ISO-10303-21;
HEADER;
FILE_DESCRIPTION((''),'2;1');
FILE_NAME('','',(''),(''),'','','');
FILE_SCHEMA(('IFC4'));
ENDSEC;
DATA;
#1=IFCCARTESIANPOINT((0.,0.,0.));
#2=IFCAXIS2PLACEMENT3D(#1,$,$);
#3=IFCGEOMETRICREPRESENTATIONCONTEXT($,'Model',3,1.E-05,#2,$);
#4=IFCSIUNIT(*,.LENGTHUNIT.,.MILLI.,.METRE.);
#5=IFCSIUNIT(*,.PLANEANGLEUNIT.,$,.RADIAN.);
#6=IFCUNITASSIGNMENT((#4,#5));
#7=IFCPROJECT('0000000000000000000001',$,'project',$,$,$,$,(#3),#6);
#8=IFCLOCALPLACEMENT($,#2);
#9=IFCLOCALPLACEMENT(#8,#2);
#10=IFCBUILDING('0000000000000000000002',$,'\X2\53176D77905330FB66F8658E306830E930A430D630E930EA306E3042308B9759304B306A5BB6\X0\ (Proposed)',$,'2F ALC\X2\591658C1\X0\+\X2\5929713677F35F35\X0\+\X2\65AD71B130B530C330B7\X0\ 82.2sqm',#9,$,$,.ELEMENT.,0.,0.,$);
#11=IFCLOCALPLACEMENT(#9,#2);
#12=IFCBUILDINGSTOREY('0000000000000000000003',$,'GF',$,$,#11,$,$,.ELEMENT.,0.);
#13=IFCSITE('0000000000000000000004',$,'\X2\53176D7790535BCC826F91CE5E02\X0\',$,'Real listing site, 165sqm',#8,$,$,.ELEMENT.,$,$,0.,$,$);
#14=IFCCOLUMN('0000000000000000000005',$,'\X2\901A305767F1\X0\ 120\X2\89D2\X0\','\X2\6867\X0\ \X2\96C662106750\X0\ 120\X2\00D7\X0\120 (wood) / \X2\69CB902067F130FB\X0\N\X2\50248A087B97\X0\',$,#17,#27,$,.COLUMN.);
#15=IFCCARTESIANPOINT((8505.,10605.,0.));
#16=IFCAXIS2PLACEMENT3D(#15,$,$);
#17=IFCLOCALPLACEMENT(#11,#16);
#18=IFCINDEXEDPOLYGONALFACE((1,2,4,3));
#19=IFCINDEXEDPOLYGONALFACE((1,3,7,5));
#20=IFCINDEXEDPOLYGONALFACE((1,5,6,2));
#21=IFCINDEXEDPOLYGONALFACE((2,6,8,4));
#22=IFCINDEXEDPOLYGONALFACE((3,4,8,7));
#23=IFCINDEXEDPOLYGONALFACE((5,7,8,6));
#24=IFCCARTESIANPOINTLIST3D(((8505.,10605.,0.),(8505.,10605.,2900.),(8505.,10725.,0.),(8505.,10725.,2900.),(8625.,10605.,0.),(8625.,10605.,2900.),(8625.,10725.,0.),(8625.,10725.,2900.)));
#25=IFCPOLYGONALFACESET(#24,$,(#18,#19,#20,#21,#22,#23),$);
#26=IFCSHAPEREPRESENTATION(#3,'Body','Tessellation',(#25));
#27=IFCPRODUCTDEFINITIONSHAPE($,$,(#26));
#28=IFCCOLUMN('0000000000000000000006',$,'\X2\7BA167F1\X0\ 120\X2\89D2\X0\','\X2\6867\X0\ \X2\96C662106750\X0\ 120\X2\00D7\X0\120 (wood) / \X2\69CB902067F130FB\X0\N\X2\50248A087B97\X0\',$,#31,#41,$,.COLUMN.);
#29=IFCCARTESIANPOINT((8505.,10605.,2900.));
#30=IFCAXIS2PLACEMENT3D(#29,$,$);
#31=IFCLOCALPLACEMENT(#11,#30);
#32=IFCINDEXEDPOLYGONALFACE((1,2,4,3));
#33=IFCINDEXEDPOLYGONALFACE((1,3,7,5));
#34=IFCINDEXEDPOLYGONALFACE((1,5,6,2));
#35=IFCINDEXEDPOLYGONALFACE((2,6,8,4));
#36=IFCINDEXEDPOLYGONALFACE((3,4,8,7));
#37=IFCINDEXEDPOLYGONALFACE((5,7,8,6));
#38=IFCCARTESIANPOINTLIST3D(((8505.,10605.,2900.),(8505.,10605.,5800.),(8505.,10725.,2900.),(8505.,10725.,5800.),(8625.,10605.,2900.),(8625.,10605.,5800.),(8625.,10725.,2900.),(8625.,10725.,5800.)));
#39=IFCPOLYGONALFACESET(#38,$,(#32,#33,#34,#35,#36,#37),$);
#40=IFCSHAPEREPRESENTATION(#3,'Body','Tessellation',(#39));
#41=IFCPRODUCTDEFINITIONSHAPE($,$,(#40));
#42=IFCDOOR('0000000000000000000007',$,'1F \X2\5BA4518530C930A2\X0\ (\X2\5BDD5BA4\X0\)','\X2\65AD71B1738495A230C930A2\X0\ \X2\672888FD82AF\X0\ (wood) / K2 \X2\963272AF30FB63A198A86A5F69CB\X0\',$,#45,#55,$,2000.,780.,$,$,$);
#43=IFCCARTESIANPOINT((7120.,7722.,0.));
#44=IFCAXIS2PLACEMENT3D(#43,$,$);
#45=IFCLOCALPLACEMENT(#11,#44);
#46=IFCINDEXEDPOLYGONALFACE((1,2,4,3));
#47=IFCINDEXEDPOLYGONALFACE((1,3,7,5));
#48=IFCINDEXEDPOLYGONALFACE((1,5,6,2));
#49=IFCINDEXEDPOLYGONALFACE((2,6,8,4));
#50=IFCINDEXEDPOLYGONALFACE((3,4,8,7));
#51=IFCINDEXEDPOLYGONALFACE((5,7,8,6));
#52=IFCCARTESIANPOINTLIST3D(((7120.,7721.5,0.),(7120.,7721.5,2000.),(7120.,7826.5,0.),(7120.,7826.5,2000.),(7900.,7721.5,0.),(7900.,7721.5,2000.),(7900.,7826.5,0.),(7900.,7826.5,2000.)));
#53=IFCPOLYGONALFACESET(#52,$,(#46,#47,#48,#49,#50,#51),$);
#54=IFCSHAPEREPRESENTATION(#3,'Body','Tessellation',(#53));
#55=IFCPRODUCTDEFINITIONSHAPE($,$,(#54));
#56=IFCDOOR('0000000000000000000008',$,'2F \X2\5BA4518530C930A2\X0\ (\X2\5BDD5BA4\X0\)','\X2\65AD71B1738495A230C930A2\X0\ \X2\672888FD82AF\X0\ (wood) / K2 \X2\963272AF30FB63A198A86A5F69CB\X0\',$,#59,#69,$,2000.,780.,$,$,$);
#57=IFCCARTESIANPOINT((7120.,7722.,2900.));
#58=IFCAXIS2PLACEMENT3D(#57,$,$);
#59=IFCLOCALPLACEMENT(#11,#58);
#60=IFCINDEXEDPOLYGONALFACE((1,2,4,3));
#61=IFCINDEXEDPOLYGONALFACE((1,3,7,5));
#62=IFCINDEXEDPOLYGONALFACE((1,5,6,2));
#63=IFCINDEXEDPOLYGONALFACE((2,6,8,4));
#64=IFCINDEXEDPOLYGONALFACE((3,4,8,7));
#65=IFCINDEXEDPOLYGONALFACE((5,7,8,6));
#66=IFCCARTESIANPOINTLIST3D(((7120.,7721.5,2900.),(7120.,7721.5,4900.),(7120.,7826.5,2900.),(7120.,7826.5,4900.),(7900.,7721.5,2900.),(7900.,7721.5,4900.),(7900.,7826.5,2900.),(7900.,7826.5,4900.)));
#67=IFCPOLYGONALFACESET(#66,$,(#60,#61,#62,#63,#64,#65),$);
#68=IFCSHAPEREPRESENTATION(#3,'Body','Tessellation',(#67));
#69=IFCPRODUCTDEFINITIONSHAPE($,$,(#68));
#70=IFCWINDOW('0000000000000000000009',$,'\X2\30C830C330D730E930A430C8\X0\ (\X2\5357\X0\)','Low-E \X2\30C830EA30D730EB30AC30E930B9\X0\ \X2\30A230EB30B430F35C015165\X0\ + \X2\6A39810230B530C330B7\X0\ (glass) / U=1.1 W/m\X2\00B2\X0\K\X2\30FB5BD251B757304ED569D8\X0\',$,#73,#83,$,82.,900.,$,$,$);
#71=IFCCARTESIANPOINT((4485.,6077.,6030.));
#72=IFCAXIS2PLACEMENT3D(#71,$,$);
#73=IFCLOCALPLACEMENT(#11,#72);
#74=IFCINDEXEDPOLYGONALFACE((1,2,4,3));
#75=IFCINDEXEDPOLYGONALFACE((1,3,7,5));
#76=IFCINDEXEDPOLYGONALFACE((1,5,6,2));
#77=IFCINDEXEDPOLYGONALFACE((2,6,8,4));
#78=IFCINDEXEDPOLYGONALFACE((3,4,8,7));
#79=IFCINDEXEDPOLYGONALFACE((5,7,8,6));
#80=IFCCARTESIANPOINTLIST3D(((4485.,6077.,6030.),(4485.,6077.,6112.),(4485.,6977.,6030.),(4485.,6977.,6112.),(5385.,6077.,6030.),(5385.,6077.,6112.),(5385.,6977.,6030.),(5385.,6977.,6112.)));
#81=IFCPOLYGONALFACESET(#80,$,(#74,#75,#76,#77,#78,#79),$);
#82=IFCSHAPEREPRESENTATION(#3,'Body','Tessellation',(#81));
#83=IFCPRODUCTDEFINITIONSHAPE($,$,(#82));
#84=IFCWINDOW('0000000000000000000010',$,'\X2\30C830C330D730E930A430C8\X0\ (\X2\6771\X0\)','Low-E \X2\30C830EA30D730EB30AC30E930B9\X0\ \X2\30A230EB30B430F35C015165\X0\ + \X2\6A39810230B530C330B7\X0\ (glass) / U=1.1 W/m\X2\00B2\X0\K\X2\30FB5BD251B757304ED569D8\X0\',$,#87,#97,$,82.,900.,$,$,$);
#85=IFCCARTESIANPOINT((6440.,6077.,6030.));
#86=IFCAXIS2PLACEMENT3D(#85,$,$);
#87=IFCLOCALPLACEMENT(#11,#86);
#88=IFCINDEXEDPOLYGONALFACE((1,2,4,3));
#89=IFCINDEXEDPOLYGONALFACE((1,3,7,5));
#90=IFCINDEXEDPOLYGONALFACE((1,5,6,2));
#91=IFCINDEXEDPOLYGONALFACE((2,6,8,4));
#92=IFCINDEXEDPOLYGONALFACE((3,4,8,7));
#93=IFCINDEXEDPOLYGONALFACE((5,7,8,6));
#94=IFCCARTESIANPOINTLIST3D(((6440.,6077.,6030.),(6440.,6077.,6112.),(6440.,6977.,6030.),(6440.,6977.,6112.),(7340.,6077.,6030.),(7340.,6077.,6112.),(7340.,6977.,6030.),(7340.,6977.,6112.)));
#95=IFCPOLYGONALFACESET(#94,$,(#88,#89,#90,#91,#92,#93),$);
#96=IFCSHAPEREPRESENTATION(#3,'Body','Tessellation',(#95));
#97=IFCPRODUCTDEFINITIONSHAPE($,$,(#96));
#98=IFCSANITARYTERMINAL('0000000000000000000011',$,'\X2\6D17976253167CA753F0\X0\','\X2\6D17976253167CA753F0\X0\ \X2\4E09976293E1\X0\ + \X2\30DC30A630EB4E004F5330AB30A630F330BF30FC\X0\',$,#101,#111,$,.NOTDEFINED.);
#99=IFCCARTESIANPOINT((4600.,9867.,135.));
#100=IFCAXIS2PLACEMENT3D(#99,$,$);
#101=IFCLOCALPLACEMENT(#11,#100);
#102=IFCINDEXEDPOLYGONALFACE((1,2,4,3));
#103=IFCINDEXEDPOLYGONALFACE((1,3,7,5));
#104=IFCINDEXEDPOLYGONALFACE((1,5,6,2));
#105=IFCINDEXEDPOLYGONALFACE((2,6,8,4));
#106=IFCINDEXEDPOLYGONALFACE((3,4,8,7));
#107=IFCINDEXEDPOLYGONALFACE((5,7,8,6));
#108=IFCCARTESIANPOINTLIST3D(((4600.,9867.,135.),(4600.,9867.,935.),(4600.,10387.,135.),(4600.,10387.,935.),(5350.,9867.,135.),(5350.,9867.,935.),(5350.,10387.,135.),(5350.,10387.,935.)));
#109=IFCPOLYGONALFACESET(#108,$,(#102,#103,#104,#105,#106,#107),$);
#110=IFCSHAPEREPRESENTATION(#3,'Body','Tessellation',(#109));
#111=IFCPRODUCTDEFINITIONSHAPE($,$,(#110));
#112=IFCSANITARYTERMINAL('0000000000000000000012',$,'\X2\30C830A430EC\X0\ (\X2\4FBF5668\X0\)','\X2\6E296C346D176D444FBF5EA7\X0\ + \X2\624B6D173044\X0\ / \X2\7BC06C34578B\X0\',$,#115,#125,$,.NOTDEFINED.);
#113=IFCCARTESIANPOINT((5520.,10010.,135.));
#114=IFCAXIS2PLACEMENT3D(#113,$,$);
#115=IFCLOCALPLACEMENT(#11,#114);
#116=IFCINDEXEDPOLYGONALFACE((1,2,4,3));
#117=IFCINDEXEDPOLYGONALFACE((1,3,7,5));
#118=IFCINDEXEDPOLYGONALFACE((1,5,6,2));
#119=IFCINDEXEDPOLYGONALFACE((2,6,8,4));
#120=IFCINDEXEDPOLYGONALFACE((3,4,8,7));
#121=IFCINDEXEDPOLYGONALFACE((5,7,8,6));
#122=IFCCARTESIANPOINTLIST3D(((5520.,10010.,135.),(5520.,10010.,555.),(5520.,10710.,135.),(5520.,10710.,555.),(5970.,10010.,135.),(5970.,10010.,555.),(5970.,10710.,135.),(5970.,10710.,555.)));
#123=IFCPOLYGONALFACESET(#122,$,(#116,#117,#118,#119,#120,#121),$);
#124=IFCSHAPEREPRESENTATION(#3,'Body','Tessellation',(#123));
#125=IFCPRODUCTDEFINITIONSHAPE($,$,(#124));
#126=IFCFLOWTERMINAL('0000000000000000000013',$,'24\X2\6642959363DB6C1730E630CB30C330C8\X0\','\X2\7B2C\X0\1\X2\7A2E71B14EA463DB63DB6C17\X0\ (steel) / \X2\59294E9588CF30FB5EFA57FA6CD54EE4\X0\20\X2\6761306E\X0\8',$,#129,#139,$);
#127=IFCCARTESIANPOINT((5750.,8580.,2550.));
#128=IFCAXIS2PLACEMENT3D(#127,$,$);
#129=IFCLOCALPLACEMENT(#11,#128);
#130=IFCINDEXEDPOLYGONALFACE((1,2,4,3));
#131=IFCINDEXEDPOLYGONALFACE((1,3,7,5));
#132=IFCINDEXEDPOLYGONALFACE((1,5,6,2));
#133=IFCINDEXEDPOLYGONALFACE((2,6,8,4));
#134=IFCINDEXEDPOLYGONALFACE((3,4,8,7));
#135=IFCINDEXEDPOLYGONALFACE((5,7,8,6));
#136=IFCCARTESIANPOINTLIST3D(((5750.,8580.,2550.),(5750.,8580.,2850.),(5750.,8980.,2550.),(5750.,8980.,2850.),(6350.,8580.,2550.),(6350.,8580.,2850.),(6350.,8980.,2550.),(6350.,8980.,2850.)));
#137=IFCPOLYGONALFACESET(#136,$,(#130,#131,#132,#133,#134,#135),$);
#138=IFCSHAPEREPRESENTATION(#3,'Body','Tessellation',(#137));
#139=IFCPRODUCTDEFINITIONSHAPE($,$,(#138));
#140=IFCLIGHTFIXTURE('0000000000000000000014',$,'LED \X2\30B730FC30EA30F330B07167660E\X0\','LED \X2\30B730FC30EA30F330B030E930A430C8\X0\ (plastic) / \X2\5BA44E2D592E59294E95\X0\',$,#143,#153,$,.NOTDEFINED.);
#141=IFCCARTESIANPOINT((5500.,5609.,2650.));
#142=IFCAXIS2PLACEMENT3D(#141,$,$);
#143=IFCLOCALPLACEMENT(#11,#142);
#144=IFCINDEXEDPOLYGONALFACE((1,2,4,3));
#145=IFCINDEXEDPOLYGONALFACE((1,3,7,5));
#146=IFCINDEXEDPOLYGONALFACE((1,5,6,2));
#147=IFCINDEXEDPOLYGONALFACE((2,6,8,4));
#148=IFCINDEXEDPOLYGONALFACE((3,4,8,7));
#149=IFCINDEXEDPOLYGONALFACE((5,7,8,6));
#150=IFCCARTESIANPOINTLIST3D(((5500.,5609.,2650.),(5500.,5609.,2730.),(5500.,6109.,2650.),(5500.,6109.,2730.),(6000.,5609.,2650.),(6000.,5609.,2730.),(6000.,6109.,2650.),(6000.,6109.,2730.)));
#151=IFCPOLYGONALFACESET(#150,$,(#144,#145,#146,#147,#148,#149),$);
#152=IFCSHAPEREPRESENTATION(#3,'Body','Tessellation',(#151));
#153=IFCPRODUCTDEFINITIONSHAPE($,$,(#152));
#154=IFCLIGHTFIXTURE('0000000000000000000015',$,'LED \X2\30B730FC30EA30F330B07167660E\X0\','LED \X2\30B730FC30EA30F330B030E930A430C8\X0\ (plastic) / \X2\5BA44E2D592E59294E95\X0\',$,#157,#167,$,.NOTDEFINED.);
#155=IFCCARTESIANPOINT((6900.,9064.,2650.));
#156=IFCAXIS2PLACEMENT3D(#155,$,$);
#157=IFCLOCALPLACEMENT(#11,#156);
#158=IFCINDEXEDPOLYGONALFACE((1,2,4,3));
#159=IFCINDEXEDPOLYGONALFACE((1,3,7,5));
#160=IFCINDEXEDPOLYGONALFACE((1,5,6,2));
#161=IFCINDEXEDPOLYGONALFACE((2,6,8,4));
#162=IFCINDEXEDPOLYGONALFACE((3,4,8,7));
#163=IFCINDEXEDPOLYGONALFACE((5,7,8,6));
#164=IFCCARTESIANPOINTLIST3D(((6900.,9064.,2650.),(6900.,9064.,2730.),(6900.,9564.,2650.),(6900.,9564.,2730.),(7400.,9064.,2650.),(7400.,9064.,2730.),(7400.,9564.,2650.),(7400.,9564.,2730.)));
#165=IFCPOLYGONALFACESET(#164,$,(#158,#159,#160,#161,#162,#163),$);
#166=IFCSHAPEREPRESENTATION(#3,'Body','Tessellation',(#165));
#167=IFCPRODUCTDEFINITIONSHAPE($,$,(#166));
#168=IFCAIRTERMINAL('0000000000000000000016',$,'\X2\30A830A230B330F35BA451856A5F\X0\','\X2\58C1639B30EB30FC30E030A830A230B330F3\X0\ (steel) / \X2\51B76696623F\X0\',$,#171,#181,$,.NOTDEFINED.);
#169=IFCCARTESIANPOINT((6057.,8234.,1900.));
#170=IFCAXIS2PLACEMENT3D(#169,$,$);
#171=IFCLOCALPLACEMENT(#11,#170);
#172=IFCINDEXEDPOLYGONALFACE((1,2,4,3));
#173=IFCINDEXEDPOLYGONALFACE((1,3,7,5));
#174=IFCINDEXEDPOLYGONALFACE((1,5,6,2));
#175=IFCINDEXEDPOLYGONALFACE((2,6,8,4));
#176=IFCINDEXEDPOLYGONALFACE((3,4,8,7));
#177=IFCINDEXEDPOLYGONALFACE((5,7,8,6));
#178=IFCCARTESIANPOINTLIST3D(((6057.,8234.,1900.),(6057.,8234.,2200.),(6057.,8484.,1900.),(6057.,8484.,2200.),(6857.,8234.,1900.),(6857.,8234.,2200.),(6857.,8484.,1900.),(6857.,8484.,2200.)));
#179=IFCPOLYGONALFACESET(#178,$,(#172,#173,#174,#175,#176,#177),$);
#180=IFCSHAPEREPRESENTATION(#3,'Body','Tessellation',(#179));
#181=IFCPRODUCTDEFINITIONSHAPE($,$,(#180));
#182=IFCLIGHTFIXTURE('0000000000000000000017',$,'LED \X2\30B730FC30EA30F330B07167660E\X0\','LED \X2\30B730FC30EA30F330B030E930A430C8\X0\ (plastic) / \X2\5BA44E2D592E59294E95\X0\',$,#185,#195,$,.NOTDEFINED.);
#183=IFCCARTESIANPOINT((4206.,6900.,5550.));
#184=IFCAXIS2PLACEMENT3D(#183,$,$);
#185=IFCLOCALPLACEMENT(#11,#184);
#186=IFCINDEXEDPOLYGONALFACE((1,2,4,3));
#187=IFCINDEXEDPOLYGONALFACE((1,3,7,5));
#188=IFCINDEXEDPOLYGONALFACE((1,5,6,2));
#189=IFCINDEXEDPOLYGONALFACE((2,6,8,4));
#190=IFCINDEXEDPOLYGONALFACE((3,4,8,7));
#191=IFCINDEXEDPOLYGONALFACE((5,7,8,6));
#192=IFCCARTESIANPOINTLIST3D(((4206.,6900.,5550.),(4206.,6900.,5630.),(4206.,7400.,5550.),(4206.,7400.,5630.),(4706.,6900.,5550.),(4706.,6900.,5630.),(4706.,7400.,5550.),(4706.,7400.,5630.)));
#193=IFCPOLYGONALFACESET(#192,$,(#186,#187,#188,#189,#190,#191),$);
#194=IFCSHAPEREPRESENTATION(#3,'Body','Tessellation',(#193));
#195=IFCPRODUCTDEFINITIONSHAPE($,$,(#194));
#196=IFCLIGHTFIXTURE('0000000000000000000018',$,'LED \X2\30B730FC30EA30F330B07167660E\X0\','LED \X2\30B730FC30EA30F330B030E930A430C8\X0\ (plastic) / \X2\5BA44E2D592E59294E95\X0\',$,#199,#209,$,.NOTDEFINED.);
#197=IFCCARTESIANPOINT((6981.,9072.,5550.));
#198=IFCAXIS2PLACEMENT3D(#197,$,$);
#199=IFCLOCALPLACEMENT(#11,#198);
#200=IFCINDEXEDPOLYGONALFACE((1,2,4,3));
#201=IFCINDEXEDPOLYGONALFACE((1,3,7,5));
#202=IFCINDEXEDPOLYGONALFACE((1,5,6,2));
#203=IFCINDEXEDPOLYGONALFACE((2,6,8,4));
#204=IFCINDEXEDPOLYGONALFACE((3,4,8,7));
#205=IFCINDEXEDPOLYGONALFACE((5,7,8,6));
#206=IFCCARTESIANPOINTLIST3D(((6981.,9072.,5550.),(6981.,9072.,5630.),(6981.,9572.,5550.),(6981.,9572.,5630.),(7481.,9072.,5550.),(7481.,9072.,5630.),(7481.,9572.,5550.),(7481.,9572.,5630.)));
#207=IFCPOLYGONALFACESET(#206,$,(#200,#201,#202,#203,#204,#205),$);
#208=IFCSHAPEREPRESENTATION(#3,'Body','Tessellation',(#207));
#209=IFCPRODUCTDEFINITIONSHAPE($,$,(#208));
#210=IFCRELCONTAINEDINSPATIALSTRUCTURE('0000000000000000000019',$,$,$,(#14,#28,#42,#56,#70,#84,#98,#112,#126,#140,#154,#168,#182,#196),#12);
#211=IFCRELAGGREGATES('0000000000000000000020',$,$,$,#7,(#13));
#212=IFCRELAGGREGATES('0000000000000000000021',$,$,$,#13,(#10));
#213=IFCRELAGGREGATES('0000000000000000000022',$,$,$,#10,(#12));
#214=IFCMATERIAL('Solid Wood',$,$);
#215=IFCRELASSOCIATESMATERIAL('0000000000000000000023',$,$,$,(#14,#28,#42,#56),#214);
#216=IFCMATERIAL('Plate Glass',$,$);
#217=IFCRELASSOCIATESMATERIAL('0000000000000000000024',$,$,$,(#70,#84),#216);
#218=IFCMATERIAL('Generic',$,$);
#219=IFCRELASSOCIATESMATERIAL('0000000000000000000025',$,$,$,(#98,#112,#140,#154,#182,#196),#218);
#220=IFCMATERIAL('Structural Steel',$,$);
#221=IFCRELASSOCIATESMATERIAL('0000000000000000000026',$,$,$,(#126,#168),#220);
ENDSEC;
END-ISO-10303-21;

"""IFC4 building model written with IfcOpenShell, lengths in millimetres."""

from ifc_helpers import new_model, si_unit, frame, frame_2d, origin, place, context, project, spatial, rectangle, extrude, material, element, save


model = new_model("IFC4")

# Units and contexts
model_context = context("Model", 3, precision=1e-05, world=origin())
ifc_project = project(units=[si_unit("LENGTHUNIT", "METRE", prefix="MILLI"), si_unit("PLANEANGLEUNIT", "RADIAN")], contexts=[model_context])

# Site, building, storey
site_placement = place(None, origin())
site = spatial("IfcSite", under=ifc_project, at=site_placement, Name="北海道富良野市", ObjectType="Real listing site, 165sqm", CompositionType="ELEMENT", RefElevation=0.0)
building_placement = place(site_placement, origin())
building = spatial("IfcBuilding", under=site, at=building_placement, Name="北海道・書斎とライブラリのある静かな家 (Proposed)", ObjectType="2F ALC外壁+天然石張+断熱サッシ 82.2sqm", CompositionType="ELEMENT", ElevationOfRefHeight=0.0, ElevationOfTerrain=0.0)
storey_placement = place(building_placement, origin())
storey = spatial("IfcBuildingStorey", under=building, at=storey_placement, Name="GF", CompositionType="ELEMENT", Elevation=0.0)

# Columns
ifc_material_1 = material(Name="Solid Wood")
column_1_placement = place(storey_placement, frame((8505.0, 10605.0, 0.0)))
element("IfcColumn", 1, at=column_1_placement, inside=storey, material=ifc_material_1, Name="通し柱 120角", Description="桧 集成材 120×120 (wood) / 構造柱・N値計算", PredefinedType="COLUMN", context=model_context, shape_type="SweptSolid", body=[
    extrude(rectangle(XDim=120.0, YDim=120.0, at=frame_2d((60.0, 60.0))), frame((8505.0, 10605.0, 0.0)), (0.0, 0.0, 1.0), 2900.0),
])
column_2_placement = place(storey_placement, frame((8505.0, 10605.0, 2900.0)))
element("IfcColumn", 2, at=column_2_placement, inside=storey, material=ifc_material_1, Name="管柱 120角", Description="桧 集成材 120×120 (wood) / 構造柱・N値計算", PredefinedType="COLUMN", context=model_context, shape_type="SweptSolid", body=[
    extrude(rectangle(XDim=120.0, YDim=120.0, at=frame_2d((60.0, 60.0))), frame((8505.0, 10605.0, 2900.0)), (0.0, 0.0, 1.0), 2900.0),
])

# Door
door_1_placement = place(storey_placement, frame((7120.0, 7722.0, 0.0)))
element("IfcDoor", 3, at=door_1_placement, inside=storey, material=ifc_material_1, Name="1F 室内ドア (寝室)", Description="断熱玄関ドア 木製芯 (wood) / K2 防犯・採風機構", OverallHeight=2000.0, OverallWidth=780.0, context=model_context, shape_type="SweptSolid", body=[
    extrude(rectangle(XDim=780.0, YDim=105.0, at=frame_2d((390.0, 52.0))), frame((7120.0, 7722.0, 0.0)), (0.0, 0.0, 1.0), 2000.0),
])

# Door
door_2_placement = place(storey_placement, frame((7120.0, 7722.0, 2900.0)))
element("IfcDoor", 4, at=door_2_placement, inside=storey, material=ifc_material_1, Name="2F 室内ドア (寝室)", Description="断熱玄関ドア 木製芯 (wood) / K2 防犯・採風機構", OverallHeight=2000.0, OverallWidth=780.0, context=model_context, shape_type="SweptSolid", body=[
    extrude(rectangle(XDim=780.0, YDim=105.0, at=frame_2d((390.0, 52.0))), frame((7120.0, 7722.0, 2900.0)), (0.0, 0.0, 1.0), 2000.0),
])

# Windows
ifc_material_2 = material(Name="Plate Glass")
window_1_placement = place(storey_placement, frame((4485.0, 6077.0, 6030.0)))
element("IfcWindow", 5, at=window_1_placement, inside=storey, material=ifc_material_2, Name="トップライト (南)", Description="Low-E トリプルガラス アルゴン封入 + 樹脂サッシ (glass) / U=1.1 W/m²K・寒冷地仕様", OverallHeight=82.0, OverallWidth=900.0, context=model_context, shape_type="SweptSolid", body=[
    extrude(rectangle(XDim=900.0, YDim=900.0, at=frame_2d((450.0, 450.0))), frame((4485.0, 6077.0, 6030.0)), (0.0, 0.0, 1.0), 82.0),
])
window_2_placement = place(storey_placement, frame((6440.0, 6077.0, 6030.0)))
element("IfcWindow", 6, at=window_2_placement, inside=storey, material=ifc_material_2, Name="トップライト (東)", Description="Low-E トリプルガラス アルゴン封入 + 樹脂サッシ (glass) / U=1.1 W/m²K・寒冷地仕様", OverallHeight=82.0, OverallWidth=900.0, context=model_context, shape_type="SweptSolid", body=[
    extrude(rectangle(XDim=900.0, YDim=900.0, at=frame_2d((450.0, 450.0))), frame((6440.0, 6077.0, 6030.0)), (0.0, 0.0, 1.0), 82.0),
])

# Sanitary terminals
ifc_material_3 = material(Name="Generic")
sanitary_terminal_1_placement = place(storey_placement, frame((4600.0, 9867.0, 135.0)))
element("IfcSanitaryTerminal", 7, at=sanitary_terminal_1_placement, inside=storey, material=ifc_material_3, Name="洗面化粧台", Description="洗面化粧台 三面鏡 + ボウル一体カウンター", PredefinedType="NOTDEFINED", context=model_context, shape_type="SweptSolid", body=[
    extrude(rectangle(XDim=750.0, YDim=520.0, at=frame_2d((375.0, 260.0))), frame((4600.0, 9867.0, 135.0)), (0.0, 0.0, 1.0), 800.0),
])
sanitary_terminal_2_placement = place(storey_placement, frame((5520.0, 10010.0, 135.0)))
element("IfcSanitaryTerminal", 8, at=sanitary_terminal_2_placement, inside=storey, material=ifc_material_3, Name="トイレ (便器)", Description="温水洗浄便座 + 手洗い / 節水型", PredefinedType="NOTDEFINED", context=model_context, shape_type="SweptSolid", body=[
    extrude(rectangle(XDim=450.0, YDim=700.0, at=frame_2d((225.0, 350.0))), frame((5520.0, 10010.0, 135.0)), (0.0, 0.0, 1.0), 420.0),
])

# Flow terminal
ifc_material_4 = material(Name="Structural Steel")
flow_terminal_placement = place(storey_placement, frame((5750.0, 8580.0, 2550.0)))
element("IfcFlowTerminal", 9, at=flow_terminal_placement, inside=storey, material=ifc_material_4, Name="24時間換気ユニット", Description="第1種熱交換換気 (steel) / 天井裏・建基法令20条の8", context=model_context, shape_type="SweptSolid", body=[
    extrude(rectangle(XDim=600.0, YDim=400.0, at=frame_2d((300.0, 200.0))), frame((5750.0, 8580.0, 2550.0)), (0.0, 0.0, 1.0), 300.0),
])

# Light fixtures
light_fixture_1_placement = place(storey_placement, frame((5500.0, 5609.0, 2650.0)))
element("IfcLightFixture", 10, at=light_fixture_1_placement, inside=storey, material=ifc_material_3, Name="LED シーリング照明", Description="LED シーリングライト (plastic) / 室中央天井", PredefinedType="NOTDEFINED", context=model_context, shape_type="SweptSolid", body=[
    extrude(rectangle(XDim=500.0, YDim=500.0, at=frame_2d((250.0, 250.0))), frame((5500.0, 5609.0, 2650.0)), (0.0, 0.0, 1.0), 80.0),
])
light_fixture_2_placement = place(storey_placement, frame((6900.0, 9064.0, 2650.0)))
element("IfcLightFixture", 11, at=light_fixture_2_placement, inside=storey, material=ifc_material_3, Name="LED シーリング照明", Description="LED シーリングライト (plastic) / 室中央天井", PredefinedType="NOTDEFINED", context=model_context, shape_type="SweptSolid", body=[
    extrude(rectangle(XDim=500.0, YDim=500.0, at=frame_2d((250.0, 250.0))), frame((6900.0, 9064.0, 2650.0)), (0.0, 0.0, 1.0), 80.0),
])

# Air terminal
air_terminal_placement = place(storey_placement, frame((6057.0, 8234.0, 1900.0)))
element("IfcAirTerminal", 12, at=air_terminal_placement, inside=storey, material=ifc_material_4, Name="エアコン室内機", Description="壁掛ルームエアコン (steel) / 冷暖房", PredefinedType="NOTDEFINED", context=model_context, shape_type="SweptSolid", body=[
    extrude(rectangle(XDim=800.0, YDim=250.0, at=frame_2d((400.0, 125.0))), frame((6057.0, 8234.0, 1900.0)), (0.0, 0.0, 1.0), 300.0),
])

# Light fixtures
light_fixture_3_placement = place(storey_placement, frame((4206.0, 6900.0, 5550.0)))
element("IfcLightFixture", 13, at=light_fixture_3_placement, inside=storey, material=ifc_material_3, Name="LED シーリング照明", Description="LED シーリングライト (plastic) / 室中央天井", PredefinedType="NOTDEFINED", context=model_context, shape_type="SweptSolid", body=[
    extrude(rectangle(XDim=500.0, YDim=500.0, at=frame_2d((250.0, 250.0))), frame((4206.0, 6900.0, 5550.0)), (0.0, 0.0, 1.0), 80.0),
])
light_fixture_4_placement = place(storey_placement, frame((6981.0, 9072.0, 5550.0)))
element("IfcLightFixture", 14, at=light_fixture_4_placement, inside=storey, material=ifc_material_3, Name="LED シーリング照明", Description="LED シーリングライト (plastic) / 室中央天井", PredefinedType="NOTDEFINED", context=model_context, shape_type="SweptSolid", body=[
    extrude(rectangle(XDim=500.0, YDim=500.0, at=frame_2d((250.0, 250.0))), frame((6981.0, 9072.0, 5550.0)), (0.0, 0.0, 1.0), 80.0),
])

save(model, "model.ifc")
